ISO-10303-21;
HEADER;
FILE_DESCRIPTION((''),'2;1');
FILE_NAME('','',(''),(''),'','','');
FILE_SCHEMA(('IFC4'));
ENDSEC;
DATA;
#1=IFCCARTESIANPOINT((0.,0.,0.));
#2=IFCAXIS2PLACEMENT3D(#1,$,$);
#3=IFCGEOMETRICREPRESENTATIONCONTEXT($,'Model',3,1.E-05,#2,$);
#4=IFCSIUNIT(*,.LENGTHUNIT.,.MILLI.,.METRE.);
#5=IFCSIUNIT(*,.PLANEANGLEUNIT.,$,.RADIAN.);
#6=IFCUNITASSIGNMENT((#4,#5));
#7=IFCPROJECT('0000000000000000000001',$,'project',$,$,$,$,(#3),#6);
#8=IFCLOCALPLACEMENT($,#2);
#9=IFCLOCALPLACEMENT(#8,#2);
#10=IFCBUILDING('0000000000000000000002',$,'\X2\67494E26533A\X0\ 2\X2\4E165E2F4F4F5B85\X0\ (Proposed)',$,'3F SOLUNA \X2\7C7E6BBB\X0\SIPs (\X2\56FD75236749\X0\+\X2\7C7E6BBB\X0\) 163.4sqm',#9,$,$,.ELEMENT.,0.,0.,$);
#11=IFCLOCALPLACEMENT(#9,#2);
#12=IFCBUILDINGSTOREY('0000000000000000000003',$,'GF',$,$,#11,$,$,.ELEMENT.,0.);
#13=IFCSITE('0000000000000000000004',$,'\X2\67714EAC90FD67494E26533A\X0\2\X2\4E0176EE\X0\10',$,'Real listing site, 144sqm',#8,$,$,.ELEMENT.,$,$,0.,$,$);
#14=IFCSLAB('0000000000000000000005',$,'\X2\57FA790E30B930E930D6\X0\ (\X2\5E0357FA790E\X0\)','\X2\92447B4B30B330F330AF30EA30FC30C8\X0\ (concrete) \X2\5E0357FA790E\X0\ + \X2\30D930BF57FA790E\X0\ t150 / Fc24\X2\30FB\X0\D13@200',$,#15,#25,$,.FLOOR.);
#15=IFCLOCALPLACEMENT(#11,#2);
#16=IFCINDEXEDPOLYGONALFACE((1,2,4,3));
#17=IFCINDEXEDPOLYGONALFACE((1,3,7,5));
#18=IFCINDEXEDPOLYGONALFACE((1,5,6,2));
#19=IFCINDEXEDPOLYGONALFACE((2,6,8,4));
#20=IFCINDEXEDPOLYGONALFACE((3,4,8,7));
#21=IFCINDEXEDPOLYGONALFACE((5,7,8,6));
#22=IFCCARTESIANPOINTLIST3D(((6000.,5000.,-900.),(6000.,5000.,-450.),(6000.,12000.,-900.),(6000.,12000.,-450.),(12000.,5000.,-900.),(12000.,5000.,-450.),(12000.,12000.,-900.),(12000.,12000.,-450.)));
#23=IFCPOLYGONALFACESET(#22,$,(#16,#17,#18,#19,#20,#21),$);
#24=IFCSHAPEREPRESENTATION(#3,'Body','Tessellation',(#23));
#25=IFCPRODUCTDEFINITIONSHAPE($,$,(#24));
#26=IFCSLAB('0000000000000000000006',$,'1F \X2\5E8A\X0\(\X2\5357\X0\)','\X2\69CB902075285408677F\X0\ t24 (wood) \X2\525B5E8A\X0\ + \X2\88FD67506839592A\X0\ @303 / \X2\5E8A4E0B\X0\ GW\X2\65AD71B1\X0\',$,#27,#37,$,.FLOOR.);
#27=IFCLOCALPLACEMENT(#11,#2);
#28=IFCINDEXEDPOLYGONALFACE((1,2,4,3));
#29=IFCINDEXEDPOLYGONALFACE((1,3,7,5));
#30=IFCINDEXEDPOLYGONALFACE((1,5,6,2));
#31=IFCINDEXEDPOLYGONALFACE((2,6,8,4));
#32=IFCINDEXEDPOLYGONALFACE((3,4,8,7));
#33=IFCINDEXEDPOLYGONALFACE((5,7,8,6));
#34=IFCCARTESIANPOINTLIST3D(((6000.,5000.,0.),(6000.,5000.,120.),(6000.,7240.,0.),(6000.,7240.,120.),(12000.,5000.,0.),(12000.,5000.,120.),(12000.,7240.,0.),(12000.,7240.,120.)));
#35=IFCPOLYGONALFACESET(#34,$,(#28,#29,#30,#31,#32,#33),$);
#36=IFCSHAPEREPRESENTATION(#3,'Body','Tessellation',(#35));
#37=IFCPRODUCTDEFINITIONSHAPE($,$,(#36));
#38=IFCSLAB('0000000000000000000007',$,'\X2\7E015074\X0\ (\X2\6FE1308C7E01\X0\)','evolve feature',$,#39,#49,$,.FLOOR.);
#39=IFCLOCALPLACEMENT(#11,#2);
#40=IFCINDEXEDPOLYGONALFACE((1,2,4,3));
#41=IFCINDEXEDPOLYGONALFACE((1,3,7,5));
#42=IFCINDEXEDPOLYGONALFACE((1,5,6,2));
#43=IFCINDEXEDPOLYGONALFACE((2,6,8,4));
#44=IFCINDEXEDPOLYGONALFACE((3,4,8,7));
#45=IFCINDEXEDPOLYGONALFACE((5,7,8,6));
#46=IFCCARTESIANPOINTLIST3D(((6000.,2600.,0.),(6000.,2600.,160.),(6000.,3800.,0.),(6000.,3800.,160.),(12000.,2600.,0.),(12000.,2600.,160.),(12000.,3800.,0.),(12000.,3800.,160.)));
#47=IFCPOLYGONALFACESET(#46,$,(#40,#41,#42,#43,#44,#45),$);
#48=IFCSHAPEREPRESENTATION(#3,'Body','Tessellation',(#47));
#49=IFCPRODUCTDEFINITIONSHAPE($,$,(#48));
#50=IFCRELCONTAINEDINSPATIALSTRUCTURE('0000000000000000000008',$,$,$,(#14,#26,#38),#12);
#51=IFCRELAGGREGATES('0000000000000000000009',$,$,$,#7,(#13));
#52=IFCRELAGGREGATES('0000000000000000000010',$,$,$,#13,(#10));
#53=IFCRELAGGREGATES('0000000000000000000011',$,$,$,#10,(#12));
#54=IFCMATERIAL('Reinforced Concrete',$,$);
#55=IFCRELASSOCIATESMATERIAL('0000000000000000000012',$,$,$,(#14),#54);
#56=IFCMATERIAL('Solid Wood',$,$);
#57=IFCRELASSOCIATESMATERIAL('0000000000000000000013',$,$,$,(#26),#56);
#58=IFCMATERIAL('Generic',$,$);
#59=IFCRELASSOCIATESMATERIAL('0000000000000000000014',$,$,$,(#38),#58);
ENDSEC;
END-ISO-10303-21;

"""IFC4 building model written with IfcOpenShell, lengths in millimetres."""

from ifc_helpers import new_model, si_unit, frame, frame_2d, origin, place, context, project, spatial, rectangle, extrude, material, element, save


model = new_model("IFC4")

# Units and contexts
model_context = context("Model", 3, precision=1e-05, world=origin())
ifc_project = project(units=[si_unit("LENGTHUNIT", "METRE", prefix="MILLI"), si_unit("PLANEANGLEUNIT", "RADIAN")], contexts=[model_context])

# Site, building, storey
site_placement = place(None, origin())
site = spatial("IfcSite", under=ifc_project, at=site_placement, Name="東京都杉並区2丁目10", ObjectType="Real listing site, 144sqm", CompositionType="ELEMENT", RefElevation=0.0)
building_placement = place(site_placement, origin())
building = spatial("IfcBuilding", under=site, at=building_placement, Name="杉並区 2世帯住宅 (Proposed)", ObjectType="3F SOLUNA 籾殻SIPs (国産杉+籾殻) 163.4sqm", CompositionType="ELEMENT", ElevationOfRefHeight=0.0, ElevationOfTerrain=0.0)
storey_placement = place(building_placement, origin())
storey = spatial("IfcBuildingStorey", under=building, at=storey_placement, Name="GF", CompositionType="ELEMENT", Elevation=0.0)

# Slabs
ifc_material_1 = material(Name="Reinforced Concrete")
slab_1_placement = place(storey_placement, frame((3000.0, 2500.0, -450.0)))
element("IfcSlab", 1, at=slab_1_placement, inside=storey, material=ifc_material_1, Name="基礎スラブ (布基礎)", Description="鉄筋コンクリート (concrete) 布基礎 + ベタ基礎 t150 / Fc24・D13@200", PredefinedType="FLOOR", context=model_context, shape_type="SweptSolid", body=[
    extrude(rectangle(XDim=6000.0, YDim=7000.0, at=frame_2d((3000.0, 3500.0))), frame((3000.0, 2500.0, -450.0)), (0.0, 0.0, 1.0), 450.0),
])
ifc_material_2 = material(Name="Solid Wood")
slab_2_placement = place(storey_placement, frame((3000.0, 2500.0, 0.0)))
element("IfcSlab", 2, at=slab_2_placement, inside=storey, material=ifc_material_2, Name="1F 床(南)", Description="構造用合板 t24 (wood) 剛床 + 製材根太 @303 / 床下 GW断熱", PredefinedType="FLOOR", context=model_context, shape_type="SweptSolid", body=[
    extrude(rectangle(XDim=6000.0, YDim=2240.0, at=frame_2d((3000.0, 1120.0))), frame((3000.0, 2500.0, 0.0)), (0.0, 0.0, 1.0), 120.0),
])
ifc_material_3 = material(Name="Generic")
slab_3_placement = place(storey_placement, frame((3000.0, 1300.0, 0.0)))
element("IfcSlab", 3, at=slab_3_placement, inside=storey, material=ifc_material_3, Name="縁側 (濡れ縁)", Description="evolve feature", PredefinedType="FLOOR", context=model_context, shape_type="SweptSolid", body=[
    extrude(rectangle(XDim=6000.0, YDim=1200.0, at=frame_2d((3000.0, 600.0))), frame((3000.0, 1300.0, 0.0)), (0.0, 0.0, 1.0), 160.0),
])

save(model, "model.ifc")
